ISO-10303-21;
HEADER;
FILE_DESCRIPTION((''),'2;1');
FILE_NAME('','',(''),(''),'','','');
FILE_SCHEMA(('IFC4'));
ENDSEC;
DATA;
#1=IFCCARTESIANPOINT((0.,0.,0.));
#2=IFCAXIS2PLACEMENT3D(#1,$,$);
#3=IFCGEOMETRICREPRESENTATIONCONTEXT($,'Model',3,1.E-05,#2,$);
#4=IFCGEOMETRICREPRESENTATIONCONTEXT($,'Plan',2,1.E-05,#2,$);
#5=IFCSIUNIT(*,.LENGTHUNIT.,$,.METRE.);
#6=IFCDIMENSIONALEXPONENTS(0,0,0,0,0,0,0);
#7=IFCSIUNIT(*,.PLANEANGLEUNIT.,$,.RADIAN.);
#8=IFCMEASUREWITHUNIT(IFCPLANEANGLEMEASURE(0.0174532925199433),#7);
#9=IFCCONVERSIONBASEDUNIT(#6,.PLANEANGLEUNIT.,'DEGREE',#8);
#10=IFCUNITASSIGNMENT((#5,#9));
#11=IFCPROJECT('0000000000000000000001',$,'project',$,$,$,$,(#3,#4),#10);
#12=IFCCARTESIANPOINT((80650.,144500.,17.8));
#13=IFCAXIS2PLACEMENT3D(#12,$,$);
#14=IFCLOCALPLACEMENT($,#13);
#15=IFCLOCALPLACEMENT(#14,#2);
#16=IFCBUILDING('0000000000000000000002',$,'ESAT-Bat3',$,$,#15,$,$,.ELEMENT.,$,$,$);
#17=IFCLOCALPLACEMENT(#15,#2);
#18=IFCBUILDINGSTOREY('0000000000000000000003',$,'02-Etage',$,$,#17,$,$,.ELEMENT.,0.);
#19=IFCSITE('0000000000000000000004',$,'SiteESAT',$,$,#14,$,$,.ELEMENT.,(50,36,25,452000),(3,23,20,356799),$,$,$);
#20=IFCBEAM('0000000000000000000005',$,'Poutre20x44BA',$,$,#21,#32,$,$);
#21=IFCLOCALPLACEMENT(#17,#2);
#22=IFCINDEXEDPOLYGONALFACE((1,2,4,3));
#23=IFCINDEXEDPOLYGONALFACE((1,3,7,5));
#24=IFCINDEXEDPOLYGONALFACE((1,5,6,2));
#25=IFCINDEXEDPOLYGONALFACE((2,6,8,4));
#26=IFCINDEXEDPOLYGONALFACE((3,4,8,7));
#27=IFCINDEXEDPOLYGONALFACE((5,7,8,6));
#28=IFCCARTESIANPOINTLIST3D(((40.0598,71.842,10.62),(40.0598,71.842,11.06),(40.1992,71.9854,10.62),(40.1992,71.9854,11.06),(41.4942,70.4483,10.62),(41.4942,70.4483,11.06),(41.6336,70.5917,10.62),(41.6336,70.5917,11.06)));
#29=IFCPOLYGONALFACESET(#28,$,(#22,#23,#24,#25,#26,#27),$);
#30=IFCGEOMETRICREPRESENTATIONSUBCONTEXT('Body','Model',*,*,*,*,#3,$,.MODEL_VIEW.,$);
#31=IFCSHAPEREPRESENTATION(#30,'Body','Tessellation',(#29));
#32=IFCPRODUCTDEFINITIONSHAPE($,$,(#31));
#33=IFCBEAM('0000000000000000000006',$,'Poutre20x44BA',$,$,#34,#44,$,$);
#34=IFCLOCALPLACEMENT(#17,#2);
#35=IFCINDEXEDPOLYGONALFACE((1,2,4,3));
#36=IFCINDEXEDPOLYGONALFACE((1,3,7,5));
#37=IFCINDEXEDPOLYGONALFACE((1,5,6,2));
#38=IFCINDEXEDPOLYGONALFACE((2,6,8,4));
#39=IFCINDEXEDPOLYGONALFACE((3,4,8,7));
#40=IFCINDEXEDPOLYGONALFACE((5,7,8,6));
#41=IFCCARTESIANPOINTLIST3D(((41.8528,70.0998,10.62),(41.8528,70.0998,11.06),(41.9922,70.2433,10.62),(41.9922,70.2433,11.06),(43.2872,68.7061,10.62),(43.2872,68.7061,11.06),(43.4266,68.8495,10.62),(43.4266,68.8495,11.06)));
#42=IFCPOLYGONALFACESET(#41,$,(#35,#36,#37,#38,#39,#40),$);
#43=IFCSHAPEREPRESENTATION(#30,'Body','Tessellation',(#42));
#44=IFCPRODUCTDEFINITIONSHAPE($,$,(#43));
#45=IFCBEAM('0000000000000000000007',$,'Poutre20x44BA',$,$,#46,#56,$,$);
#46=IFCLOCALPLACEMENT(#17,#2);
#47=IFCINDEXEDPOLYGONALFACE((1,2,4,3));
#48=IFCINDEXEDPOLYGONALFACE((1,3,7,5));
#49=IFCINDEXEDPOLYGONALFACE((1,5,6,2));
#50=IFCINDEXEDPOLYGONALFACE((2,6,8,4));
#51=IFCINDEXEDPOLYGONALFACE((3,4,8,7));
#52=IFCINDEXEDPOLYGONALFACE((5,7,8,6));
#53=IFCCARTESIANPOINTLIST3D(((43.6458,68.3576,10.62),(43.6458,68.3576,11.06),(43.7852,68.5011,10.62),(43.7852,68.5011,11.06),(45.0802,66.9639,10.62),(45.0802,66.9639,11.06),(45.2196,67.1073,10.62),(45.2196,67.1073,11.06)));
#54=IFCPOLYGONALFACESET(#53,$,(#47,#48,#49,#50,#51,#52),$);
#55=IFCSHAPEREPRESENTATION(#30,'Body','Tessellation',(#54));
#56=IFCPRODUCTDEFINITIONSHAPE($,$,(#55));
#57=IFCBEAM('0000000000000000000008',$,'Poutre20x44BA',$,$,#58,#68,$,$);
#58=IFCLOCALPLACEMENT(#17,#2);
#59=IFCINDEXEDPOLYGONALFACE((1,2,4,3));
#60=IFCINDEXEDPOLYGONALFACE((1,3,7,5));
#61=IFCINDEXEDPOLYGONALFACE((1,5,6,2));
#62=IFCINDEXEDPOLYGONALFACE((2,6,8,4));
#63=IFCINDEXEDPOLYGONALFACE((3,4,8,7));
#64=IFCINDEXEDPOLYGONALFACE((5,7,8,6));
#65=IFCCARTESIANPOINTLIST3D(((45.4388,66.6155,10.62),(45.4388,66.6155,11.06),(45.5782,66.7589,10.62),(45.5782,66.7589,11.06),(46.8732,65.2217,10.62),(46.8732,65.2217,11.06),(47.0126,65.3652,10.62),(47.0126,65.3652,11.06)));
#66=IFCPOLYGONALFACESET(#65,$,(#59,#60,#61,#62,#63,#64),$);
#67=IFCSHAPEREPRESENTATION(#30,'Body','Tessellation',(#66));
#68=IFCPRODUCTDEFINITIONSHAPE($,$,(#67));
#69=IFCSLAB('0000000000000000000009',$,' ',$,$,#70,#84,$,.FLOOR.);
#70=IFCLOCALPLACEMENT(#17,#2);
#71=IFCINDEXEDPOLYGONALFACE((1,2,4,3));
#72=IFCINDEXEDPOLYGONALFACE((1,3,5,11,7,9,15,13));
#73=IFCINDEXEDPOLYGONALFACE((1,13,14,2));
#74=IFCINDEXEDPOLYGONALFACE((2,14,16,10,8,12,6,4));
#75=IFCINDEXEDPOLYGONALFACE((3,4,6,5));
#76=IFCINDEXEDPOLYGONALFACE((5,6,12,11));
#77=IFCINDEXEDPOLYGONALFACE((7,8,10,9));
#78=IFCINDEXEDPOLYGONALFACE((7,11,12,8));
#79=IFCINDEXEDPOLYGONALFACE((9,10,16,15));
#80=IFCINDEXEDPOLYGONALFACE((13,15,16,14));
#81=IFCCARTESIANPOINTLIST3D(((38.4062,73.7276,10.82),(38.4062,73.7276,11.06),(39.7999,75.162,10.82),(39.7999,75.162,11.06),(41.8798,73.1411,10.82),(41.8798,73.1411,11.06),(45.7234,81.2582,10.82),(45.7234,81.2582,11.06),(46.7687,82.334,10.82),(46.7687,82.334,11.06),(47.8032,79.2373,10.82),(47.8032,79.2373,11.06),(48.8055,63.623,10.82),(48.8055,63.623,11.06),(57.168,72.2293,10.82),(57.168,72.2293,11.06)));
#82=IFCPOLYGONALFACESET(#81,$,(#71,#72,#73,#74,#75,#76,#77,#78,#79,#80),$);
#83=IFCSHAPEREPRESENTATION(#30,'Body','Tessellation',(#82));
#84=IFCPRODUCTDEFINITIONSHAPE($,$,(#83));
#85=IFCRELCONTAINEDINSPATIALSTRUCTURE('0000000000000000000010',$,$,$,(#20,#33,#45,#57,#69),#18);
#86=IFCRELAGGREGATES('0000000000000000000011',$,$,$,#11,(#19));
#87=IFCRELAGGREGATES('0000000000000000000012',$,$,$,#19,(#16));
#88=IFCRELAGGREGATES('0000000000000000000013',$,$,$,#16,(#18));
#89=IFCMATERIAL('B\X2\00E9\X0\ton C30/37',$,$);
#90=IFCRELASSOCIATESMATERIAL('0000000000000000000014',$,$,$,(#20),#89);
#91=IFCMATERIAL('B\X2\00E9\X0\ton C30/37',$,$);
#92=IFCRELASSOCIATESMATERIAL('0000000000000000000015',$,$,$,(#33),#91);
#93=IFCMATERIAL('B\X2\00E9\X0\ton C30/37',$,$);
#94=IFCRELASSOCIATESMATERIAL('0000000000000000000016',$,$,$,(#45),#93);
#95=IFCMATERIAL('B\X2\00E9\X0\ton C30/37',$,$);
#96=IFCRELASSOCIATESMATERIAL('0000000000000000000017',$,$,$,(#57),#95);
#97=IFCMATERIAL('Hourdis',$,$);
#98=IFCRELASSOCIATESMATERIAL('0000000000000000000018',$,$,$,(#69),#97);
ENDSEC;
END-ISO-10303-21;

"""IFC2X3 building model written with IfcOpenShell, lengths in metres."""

from ifc_helpers import new_model, entity, si_unit, converted_unit, frame, frame_2d, origin, origin_with_axes, place, context, subcontext, project, spatial, polyline, rectangle, outline, extrude, material, element, save


model = new_model("IFC2X3")

# Units and contexts
model_context = context("Model", 3, precision=1e-05, world=origin())
plan_context = context("Plan", 2, precision=1e-05, world=origin())
body_context = subcontext(model_context, "Body", "Model", "MODEL_VIEW")
ifc_project = project(units=[si_unit("LENGTHUNIT", "METRE"), converted_unit("PLANEANGLEUNIT", "DEGREE", entity("IfcPlaneAngleMeasure", 0.0174532925199433), si_unit("PLANEANGLEUNIT", "RADIAN"), dimensions=[0, 0, 0, 0, 0, 0, 0])], contexts=[model_context, plan_context])

# Site, building, storey
site_placement = place(None, frame((80650.0, 144500.0, 17.8)))
site = spatial("IfcSite", under=ifc_project, at=site_placement, Name="SiteESAT", CompositionType="ELEMENT", RefLatitude=(50, 36, 25, 452000), RefLongitude=(3, 23, 20, 356799))
building_placement = place(site_placement, origin())
building = spatial("IfcBuilding", under=site, at=building_placement, Name="ESAT-Bat3", CompositionType="ELEMENT")
storey_placement = place(building_placement, origin())
storey = spatial("IfcBuildingStorey", under=building, at=storey_placement, Name="02-Etage", CompositionType="ELEMENT", Elevation=0.0)

# Beams
ifc_material_1 = material(Name="Béton C30/37")
beam_1_placement = place(storey_placement, frame((41.6336, 70.5917, 10.62), z_axis=(0.0, 0.0, 1.0), x_axis=(-0.717196, 0.696872, 0.0)))
element("IfcBeam", 1, at=beam_1_placement, inside=storey, material=ifc_material_1, Name="Poutre20x44BA", context=body_context, shape_type="SweptSolid", body=[
    extrude(rectangle(XDim=0.2, YDim=0.44, at=frame_2d((0.1, 0.22), x_axis=(1.0, 0.0))), frame((0.0, 0.0, 0.0), z_axis=(1.0, 0.0, 0.0), x_axis=(0.0, 1.0, 0.0)), (0.0, 0.0, 1.0), 2.0),
])
ifc_material_2 = material(Name="Béton C30/37")
beam_2_placement = place(storey_placement, frame((43.4266, 68.8495, 10.62), z_axis=(0.0, 0.0, 1.0), x_axis=(-0.717196, 0.696872, 0.0)))
element("IfcBeam", 2, at=beam_2_placement, inside=storey, material=ifc_material_2, Name="Poutre20x44BA", context=body_context, shape_type="SweptSolid", body=[
    extrude(rectangle(XDim=0.2, YDim=0.44, at=frame_2d((0.1, 0.22), x_axis=(1.0, 0.0))), frame((0.0, 0.0, 0.0), z_axis=(1.0, 0.0, 0.0), x_axis=(0.0, 1.0, 0.0)), (0.0, 0.0, 1.0), 2.0),
])
ifc_material_3 = material(Name="Béton C30/37")
beam_3_placement = place(storey_placement, frame((45.2196, 67.1073, 10.62), z_axis=(0.0, 0.0, 1.0), x_axis=(-0.717196, 0.696872, 0.0)))
element("IfcBeam", 3, at=beam_3_placement, inside=storey, material=ifc_material_3, Name="Poutre20x44BA", context=body_context, shape_type="SweptSolid", body=[
    extrude(rectangle(XDim=0.2, YDim=0.44, at=frame_2d((0.1, 0.22), x_axis=(1.0, 0.0))), frame((0.0, 0.0, 0.0), z_axis=(1.0, 0.0, 0.0), x_axis=(0.0, 1.0, 0.0)), (0.0, 0.0, 1.0), 2.0),
])
ifc_material_4 = material(Name="Béton C30/37")
beam_4_placement = place(storey_placement, frame((47.0126, 65.3652, 10.62), z_axis=(0.0, 0.0, 1.0), x_axis=(-0.717196, 0.696872, 0.0)))
element("IfcBeam", 4, at=beam_4_placement, inside=storey, material=ifc_material_4, Name="Poutre20x44BA", context=body_context, shape_type="SweptSolid", body=[
    extrude(rectangle(XDim=0.2, YDim=0.44, at=frame_2d((0.1, 0.22), x_axis=(1.0, 0.0))), frame((0.0, 0.0, 0.0), z_axis=(1.0, 0.0, 0.0), x_axis=(0.0, 1.0, 0.0)), (0.0, 0.0, 1.0), 2.0),
])

# Slab
ifc_material_5 = material(Name="Hourdis")
slab_placement = place(storey_placement, frame((38.4062, 63.623, 10.82)))
element("IfcSlab", 5, at=slab_placement, inside=storey, material=ifc_material_5, Name=" ", PredefinedType="FLOOR", context=body_context, shape_type="SweptSolid", body=[
    extrude(outline(polyline([(1.3937, 11.539), (0.0, 10.1046), (10.3993, 0.0), (18.7618, 8.6063), (8.3625, 18.711), (7.3172, 17.6352), (9.397, 15.6143), (3.4736, 9.5181), (1.3937, 11.539)])), origin_with_axes(), (0.0, 0.0, 1.0), 0.24),
])

save(model, "model.ifc")
